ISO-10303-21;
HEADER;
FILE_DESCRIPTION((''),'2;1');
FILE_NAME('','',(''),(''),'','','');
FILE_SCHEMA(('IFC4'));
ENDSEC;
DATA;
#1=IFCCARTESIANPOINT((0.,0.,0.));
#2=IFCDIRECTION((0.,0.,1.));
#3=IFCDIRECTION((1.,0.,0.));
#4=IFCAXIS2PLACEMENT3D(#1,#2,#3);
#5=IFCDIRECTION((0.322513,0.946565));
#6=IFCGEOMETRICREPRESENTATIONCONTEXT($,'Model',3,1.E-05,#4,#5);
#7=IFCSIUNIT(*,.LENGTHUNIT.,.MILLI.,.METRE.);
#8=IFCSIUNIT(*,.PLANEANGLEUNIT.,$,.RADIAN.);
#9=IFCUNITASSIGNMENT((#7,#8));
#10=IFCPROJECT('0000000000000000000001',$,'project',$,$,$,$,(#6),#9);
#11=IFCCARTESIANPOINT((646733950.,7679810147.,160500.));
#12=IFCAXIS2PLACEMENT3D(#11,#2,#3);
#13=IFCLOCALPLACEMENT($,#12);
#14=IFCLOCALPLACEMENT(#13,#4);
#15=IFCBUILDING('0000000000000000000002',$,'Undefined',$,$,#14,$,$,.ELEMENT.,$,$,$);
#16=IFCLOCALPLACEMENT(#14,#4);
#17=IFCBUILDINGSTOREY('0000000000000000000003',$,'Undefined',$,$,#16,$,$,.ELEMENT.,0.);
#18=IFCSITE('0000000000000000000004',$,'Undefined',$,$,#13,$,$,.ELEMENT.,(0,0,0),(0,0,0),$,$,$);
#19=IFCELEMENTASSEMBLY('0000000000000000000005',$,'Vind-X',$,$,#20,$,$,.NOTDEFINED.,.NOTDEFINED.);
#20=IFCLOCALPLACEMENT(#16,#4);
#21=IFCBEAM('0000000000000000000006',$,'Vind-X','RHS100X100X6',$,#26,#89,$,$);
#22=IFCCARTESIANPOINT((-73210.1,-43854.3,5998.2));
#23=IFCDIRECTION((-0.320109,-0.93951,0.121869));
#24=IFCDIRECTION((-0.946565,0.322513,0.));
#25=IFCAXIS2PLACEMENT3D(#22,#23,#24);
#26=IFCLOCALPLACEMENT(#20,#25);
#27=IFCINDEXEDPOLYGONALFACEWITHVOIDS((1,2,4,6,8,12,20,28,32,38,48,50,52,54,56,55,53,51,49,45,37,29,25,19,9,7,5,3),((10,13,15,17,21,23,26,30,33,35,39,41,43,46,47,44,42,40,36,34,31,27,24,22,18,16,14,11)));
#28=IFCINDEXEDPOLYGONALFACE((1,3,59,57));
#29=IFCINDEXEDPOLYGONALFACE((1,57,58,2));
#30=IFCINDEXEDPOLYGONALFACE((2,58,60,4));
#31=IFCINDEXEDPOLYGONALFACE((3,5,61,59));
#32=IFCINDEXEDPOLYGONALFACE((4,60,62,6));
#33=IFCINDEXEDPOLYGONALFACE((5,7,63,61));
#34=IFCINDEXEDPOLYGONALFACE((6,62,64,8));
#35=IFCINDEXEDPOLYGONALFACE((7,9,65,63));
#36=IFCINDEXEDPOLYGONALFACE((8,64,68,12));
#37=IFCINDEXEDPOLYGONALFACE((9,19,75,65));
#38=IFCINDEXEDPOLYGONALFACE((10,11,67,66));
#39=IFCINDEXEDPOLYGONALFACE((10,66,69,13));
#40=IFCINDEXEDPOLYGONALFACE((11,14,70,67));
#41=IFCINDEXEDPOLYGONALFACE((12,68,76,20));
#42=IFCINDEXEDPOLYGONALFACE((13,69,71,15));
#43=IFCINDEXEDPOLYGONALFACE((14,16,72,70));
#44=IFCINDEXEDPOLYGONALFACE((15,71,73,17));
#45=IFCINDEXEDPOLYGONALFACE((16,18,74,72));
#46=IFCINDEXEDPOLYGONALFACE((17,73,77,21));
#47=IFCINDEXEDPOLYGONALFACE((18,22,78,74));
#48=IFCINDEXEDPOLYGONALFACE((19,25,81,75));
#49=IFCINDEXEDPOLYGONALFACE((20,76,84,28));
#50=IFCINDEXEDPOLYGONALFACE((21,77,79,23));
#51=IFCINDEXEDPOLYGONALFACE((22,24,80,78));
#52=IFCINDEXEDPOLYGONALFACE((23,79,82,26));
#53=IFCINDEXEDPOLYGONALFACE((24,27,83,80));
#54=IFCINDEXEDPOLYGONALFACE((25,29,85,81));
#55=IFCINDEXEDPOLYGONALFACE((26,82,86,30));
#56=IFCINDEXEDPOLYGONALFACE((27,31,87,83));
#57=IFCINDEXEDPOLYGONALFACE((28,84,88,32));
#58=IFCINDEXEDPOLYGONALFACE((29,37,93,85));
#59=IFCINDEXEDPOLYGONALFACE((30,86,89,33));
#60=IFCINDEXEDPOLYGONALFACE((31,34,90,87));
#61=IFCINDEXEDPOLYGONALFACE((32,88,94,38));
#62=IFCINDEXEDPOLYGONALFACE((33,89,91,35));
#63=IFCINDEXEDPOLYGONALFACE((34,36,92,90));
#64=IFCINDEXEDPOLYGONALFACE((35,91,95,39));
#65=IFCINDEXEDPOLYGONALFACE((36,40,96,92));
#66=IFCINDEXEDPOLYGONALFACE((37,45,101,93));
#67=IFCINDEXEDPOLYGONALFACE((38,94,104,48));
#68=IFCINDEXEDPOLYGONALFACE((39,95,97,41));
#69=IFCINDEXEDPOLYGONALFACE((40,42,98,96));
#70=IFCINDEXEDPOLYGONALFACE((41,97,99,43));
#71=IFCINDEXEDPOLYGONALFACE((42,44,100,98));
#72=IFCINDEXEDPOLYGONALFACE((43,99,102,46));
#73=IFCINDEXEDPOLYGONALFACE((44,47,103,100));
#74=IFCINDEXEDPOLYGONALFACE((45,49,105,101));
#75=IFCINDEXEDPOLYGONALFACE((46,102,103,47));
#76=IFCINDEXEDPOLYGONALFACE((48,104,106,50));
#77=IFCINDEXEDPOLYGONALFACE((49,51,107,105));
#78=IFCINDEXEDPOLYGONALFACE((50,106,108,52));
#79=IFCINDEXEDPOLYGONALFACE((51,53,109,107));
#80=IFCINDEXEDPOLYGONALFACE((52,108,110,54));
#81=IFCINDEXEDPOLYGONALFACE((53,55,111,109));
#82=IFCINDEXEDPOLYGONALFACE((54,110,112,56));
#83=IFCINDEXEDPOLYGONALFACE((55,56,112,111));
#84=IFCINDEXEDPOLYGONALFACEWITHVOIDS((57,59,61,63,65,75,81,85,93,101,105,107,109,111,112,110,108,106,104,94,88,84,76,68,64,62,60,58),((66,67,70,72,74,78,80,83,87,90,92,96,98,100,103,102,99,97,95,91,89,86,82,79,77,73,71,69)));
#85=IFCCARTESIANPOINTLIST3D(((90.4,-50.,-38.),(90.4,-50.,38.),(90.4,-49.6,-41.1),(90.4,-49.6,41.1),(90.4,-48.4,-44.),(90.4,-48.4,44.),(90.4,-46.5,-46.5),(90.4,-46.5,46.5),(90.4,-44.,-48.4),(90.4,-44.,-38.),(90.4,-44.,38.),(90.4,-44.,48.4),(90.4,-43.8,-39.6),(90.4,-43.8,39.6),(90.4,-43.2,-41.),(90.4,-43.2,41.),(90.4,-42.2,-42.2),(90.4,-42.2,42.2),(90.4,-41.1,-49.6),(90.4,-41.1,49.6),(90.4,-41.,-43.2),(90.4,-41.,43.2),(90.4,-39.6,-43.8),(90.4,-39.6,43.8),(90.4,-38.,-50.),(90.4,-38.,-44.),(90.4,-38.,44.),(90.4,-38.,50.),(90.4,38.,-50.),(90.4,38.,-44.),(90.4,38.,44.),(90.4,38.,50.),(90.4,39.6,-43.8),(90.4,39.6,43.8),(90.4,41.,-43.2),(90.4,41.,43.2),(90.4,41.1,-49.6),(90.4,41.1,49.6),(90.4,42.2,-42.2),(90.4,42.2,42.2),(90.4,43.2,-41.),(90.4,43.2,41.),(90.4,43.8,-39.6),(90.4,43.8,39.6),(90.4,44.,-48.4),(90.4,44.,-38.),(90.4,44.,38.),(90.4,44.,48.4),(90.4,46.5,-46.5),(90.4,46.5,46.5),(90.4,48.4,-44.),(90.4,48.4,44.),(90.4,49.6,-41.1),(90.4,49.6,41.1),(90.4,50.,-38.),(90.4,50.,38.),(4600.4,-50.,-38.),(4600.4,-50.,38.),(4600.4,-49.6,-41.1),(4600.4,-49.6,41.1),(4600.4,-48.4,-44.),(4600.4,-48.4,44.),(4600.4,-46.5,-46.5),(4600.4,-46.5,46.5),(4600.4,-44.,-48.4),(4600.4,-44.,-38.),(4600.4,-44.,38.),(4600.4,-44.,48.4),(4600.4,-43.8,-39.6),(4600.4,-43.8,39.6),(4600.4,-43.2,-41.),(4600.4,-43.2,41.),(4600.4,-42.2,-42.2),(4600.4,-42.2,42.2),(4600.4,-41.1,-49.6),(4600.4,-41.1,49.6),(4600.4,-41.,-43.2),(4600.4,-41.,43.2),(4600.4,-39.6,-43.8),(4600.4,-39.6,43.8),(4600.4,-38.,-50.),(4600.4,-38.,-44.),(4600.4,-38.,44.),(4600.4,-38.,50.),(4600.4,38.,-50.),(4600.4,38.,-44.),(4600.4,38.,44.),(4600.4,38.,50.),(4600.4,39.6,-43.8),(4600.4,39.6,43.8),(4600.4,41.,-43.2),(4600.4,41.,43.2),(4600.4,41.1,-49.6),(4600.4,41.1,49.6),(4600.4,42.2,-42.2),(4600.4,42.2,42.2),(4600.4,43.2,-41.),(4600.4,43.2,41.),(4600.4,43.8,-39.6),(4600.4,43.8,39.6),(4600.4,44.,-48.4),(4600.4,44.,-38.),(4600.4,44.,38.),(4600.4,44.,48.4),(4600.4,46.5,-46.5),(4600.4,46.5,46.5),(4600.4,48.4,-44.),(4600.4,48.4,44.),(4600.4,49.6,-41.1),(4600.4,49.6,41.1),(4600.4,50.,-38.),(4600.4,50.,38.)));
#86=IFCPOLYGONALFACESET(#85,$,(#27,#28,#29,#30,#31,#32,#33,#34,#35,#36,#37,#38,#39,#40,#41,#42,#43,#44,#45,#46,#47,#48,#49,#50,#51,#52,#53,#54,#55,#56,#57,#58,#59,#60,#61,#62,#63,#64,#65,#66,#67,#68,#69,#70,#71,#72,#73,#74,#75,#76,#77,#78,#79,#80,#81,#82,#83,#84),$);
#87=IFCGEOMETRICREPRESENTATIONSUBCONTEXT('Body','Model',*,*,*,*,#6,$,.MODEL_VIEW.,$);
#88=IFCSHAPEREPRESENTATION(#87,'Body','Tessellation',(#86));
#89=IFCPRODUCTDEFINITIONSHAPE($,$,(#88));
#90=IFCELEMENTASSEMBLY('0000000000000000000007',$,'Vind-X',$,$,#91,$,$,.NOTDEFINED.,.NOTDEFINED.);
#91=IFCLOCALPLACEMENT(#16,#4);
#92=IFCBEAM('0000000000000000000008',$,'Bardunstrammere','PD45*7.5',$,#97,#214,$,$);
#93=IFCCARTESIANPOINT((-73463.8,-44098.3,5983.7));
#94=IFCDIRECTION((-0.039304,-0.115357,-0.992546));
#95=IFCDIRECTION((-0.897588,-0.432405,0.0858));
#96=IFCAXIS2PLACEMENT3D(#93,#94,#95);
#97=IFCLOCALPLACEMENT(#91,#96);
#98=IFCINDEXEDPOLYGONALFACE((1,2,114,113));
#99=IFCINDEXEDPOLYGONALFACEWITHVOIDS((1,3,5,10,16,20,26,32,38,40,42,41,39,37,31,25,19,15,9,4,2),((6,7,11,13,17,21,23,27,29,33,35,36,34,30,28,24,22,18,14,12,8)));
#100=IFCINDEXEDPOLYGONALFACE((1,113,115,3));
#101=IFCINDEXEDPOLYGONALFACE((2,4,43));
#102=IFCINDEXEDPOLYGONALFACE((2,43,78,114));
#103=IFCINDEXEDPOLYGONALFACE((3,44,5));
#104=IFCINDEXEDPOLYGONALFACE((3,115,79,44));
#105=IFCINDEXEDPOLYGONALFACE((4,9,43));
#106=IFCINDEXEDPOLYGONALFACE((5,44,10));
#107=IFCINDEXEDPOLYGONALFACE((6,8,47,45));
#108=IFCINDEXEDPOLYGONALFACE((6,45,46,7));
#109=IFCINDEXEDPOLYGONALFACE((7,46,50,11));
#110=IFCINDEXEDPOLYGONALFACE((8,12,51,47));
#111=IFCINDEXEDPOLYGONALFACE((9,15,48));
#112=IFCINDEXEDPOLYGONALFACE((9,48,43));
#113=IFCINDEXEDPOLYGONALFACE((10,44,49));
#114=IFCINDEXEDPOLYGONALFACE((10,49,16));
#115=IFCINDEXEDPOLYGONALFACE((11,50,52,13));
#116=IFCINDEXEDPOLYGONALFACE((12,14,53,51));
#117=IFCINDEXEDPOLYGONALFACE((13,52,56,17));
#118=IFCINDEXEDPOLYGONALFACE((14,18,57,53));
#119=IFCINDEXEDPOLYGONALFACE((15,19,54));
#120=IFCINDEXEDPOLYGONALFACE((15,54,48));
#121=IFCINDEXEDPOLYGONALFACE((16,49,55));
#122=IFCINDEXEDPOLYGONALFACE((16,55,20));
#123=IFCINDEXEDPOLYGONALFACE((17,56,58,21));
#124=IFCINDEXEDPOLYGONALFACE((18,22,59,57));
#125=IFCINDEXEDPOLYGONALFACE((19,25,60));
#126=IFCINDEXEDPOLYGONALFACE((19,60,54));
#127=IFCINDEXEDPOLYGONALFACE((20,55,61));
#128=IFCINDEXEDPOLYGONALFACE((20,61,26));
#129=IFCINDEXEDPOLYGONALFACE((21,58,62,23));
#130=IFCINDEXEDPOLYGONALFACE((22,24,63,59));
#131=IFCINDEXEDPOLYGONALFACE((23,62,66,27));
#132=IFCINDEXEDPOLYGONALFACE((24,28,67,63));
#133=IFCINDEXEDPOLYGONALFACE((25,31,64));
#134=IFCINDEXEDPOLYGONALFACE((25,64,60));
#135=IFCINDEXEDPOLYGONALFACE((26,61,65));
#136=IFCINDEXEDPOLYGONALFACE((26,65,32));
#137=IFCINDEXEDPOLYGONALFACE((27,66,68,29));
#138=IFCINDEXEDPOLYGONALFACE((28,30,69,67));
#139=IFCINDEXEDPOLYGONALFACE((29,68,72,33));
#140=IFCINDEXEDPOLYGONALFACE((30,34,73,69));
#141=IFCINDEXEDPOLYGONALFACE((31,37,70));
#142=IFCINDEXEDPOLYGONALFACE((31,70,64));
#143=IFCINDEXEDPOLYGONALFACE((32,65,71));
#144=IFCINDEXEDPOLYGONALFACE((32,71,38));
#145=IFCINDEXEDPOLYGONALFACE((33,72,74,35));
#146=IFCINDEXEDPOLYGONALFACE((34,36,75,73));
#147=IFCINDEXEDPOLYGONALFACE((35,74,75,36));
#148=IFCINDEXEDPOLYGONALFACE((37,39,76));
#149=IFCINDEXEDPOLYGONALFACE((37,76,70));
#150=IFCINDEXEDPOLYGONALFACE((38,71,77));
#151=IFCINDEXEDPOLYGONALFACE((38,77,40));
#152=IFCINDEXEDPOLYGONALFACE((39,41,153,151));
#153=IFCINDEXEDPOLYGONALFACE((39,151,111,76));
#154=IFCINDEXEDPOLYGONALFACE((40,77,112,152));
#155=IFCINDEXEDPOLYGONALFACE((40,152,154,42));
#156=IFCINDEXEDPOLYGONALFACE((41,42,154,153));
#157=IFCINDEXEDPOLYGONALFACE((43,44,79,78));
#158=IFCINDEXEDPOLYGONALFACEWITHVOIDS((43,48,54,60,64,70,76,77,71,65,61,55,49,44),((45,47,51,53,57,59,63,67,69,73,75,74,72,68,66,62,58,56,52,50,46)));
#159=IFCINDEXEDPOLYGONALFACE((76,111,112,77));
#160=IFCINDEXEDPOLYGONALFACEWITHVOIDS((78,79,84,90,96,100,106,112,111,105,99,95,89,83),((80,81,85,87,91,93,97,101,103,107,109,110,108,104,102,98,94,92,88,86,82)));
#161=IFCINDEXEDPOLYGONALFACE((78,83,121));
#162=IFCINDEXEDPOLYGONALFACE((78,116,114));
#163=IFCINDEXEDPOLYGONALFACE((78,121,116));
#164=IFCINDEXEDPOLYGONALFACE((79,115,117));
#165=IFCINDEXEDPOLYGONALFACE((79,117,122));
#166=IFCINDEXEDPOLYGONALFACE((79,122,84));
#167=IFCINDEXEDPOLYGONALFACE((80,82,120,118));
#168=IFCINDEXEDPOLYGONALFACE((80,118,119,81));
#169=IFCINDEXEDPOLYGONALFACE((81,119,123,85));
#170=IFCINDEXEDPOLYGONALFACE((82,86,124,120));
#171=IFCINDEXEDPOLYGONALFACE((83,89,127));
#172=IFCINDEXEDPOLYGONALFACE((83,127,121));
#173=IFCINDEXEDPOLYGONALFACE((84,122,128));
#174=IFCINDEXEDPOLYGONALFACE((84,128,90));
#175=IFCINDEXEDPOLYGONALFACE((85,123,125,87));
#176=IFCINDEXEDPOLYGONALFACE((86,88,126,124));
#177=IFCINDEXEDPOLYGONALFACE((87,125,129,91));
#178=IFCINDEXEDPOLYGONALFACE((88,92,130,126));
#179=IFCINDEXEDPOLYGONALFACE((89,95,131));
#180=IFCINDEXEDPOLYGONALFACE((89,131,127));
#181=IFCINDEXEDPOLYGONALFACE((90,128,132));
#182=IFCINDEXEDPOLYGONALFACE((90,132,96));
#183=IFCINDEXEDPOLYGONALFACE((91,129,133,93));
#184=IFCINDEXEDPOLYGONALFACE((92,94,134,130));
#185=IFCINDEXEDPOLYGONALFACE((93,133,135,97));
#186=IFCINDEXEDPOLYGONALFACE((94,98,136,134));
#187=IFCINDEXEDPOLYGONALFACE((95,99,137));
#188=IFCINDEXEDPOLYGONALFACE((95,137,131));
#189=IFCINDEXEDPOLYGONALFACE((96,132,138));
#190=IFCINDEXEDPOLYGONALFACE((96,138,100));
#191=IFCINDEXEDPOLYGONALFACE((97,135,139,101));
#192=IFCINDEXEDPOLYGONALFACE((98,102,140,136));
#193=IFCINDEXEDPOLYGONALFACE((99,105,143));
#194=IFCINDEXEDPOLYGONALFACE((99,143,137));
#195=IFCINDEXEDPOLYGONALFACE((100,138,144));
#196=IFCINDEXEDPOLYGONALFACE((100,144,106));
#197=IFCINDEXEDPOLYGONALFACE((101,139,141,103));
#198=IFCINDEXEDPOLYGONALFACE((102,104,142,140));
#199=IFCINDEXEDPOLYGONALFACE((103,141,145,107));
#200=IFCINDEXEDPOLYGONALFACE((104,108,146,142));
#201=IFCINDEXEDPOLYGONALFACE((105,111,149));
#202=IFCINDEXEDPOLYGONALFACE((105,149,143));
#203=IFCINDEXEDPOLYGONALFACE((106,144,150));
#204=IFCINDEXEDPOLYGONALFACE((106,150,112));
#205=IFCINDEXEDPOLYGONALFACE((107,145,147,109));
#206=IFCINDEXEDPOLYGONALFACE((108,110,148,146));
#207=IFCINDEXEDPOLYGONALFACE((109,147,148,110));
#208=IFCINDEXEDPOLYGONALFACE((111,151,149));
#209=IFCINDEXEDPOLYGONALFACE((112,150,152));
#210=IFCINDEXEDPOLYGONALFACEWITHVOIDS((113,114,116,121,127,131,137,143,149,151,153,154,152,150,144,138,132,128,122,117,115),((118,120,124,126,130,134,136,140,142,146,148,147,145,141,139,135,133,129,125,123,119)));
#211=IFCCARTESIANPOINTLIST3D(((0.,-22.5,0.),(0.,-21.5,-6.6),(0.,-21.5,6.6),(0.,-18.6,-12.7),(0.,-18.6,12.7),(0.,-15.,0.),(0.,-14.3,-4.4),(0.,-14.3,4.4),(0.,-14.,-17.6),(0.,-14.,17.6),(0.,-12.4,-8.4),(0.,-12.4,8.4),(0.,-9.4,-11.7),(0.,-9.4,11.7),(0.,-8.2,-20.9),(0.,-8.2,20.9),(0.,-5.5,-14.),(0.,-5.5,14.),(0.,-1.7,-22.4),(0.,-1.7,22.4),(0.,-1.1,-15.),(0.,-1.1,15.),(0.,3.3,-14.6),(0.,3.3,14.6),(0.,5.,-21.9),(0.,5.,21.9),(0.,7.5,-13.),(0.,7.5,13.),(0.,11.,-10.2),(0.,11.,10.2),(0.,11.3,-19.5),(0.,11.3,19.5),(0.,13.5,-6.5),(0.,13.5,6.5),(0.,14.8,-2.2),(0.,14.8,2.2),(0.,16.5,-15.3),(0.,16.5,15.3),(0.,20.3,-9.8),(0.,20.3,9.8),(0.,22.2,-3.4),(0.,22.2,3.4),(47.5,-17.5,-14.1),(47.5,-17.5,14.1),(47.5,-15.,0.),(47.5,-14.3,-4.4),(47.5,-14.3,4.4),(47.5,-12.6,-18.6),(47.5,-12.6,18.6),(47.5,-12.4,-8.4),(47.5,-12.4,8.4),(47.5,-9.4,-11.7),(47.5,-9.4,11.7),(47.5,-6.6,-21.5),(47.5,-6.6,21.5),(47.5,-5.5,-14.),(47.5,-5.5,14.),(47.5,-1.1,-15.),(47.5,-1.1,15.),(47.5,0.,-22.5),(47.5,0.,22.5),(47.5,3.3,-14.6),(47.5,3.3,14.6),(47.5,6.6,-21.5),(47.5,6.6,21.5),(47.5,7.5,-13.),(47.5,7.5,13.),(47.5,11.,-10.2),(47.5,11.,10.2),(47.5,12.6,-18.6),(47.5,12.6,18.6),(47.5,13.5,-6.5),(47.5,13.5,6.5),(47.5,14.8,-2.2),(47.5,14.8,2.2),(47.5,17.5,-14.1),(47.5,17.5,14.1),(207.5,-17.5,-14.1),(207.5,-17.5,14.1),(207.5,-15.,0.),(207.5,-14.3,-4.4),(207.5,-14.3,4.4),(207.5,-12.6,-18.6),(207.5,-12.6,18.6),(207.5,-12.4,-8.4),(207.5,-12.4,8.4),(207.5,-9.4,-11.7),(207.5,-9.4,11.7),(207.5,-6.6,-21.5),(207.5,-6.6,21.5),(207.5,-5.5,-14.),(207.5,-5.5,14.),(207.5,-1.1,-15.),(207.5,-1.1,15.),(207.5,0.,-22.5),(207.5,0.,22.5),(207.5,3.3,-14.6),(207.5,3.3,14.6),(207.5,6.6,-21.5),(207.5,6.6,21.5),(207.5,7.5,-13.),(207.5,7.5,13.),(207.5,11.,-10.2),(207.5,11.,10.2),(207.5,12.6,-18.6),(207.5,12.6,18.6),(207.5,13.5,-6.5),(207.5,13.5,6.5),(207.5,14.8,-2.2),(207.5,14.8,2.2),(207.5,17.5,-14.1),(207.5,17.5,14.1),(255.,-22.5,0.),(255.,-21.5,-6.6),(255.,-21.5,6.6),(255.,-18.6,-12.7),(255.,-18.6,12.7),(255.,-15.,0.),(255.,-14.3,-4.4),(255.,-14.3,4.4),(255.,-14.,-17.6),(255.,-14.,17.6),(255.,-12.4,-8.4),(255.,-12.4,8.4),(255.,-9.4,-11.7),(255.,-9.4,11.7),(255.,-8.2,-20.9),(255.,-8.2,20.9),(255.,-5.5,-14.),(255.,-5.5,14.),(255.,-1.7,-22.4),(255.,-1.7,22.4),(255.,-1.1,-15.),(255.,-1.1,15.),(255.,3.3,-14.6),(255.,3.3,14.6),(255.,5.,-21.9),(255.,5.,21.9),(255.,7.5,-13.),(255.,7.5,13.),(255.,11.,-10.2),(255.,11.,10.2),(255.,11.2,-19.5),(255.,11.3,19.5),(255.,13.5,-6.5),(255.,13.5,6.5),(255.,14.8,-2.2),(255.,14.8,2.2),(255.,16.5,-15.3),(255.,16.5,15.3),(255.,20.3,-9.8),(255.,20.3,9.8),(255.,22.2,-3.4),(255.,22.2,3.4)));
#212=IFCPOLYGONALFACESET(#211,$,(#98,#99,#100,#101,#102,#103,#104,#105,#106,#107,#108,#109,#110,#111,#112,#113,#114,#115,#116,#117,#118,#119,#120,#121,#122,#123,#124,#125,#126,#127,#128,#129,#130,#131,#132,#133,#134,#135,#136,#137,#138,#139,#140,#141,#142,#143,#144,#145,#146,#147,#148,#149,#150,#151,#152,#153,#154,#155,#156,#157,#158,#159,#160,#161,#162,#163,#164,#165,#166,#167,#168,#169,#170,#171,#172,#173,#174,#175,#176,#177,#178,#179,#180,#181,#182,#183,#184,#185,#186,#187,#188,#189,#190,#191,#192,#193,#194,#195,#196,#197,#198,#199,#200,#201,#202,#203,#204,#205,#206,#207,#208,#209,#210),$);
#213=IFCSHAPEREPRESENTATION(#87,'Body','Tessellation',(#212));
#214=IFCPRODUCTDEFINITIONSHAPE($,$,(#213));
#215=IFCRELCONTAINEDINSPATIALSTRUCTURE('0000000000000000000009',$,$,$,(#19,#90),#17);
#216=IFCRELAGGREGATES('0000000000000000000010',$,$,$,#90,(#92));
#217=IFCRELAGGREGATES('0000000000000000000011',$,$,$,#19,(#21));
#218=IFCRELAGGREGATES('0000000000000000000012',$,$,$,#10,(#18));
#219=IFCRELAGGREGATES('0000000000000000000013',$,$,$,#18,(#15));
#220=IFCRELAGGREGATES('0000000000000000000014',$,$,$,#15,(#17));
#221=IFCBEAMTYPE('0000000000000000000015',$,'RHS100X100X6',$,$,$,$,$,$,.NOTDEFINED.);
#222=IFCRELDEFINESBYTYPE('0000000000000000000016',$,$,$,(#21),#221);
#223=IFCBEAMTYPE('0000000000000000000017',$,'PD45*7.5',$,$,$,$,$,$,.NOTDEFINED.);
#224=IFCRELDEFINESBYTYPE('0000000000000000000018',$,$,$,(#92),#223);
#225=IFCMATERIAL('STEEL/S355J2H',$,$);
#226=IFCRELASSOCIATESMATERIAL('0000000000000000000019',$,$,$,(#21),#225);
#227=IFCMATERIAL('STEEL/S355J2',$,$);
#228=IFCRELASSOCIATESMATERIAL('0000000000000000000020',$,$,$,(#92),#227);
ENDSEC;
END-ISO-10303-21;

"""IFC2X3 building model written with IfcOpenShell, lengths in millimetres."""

from ifc_helpers import new_model, si_unit, direction, frame, origin_with_axes, origin_2d_with_axis, place, context, subcontext, project, spatial, rectangle, hollow_rectangle, hollow_circle, extrude, boolean, clip, halfspace, material, type_object, element, aggregate, save


model = new_model("IFC2X3")

# Units and contexts
model_context = context("Model", 3, precision=1e-05, world=origin_with_axes(), true_north=direction((0.322513, 0.946565)))
body_context = subcontext(model_context, "Body", "Model", "MODEL_VIEW")
ifc_project = project(units=[si_unit("LENGTHUNIT", "METRE", prefix="MILLI"), si_unit("PLANEANGLEUNIT", "RADIAN")], contexts=[model_context])

# Site, building, storey
site_placement = place(None, frame((646733950.0, 7679810147.0, 160500.0), z_axis=(0.0, 0.0, 1.0), x_axis=(1.0, 0.0, 0.0)))
site = spatial("IfcSite", under=ifc_project, at=site_placement, Name="Undefined", CompositionType="ELEMENT", RefLatitude=(0, 0, 0), RefLongitude=(0, 0, 0))
building_placement = place(site_placement, origin_with_axes())
building = spatial("IfcBuilding", under=site, at=building_placement, Name="Undefined", CompositionType="ELEMENT")
storey_placement = place(building_placement, origin_with_axes())
storey = spatial("IfcBuildingStorey", under=building, at=storey_placement, Name="Undefined", CompositionType="ELEMENT", Elevation=0.0)

# Element assembly, beam
ifc_material_1 = material(Name="STEEL/S355J2H")
beam_type_1 = type_object("IfcBeamType", Name="RHS100X100X6", PredefinedType="NOTDEFINED")
assembly_1_placement = place(storey_placement, origin_with_axes())
assembly_1 = element("IfcElementAssembly", 1, at=assembly_1_placement, inside=storey, Name="Vind-X", AssemblyPlace="NOTDEFINED", PredefinedType="NOTDEFINED")
beam_1_placement = place(assembly_1_placement, frame((-73210.1, -43854.3, 5998.2), z_axis=(-0.320109, -0.93951, 0.121869), x_axis=(-0.946565, 0.322513, 0.0)))
beam_1 = element("IfcBeam", 2, at=beam_1_placement, type_object=beam_type_1, material=ifc_material_1, Name="Vind-X", Description="RHS100X100X6", context=body_context, shape_type="Clipping", body=[
    clip(clip(extrude(hollow_rectangle(XDim=100.0, YDim=100.0, WallThickness=6.0, InnerFilletRadius=6.0, OuterFilletRadius=12.0, at=origin_2d_with_axis()), frame((4690.0, 0.0, 0.0), z_axis=(-1.0, 0.0, 0.0), x_axis=(0.0, -1.0, 0.0)), (0.0, 0.0, 1.0), 4690.0), halfspace(frame((4600.4, 7.5, 0.0), z_axis=(-1.0, 0.0, 0.0), x_axis=(0.0, 0.0, -1.0)), True)), halfspace(frame((90.4, 7.5, 0.0), z_axis=(1.0, 0.0, 0.0), x_axis=(0.0, 0.0, 1.0)), True)),
])

# Element assembly, beam
assembly_2_placement = place(storey_placement, origin_with_axes())
assembly_2 = element("IfcElementAssembly", 3, at=assembly_2_placement, inside=storey, Name="Vind-X", AssemblyPlace="NOTDEFINED", PredefinedType="NOTDEFINED")
ifc_material_2 = material(Name="STEEL/S355J2")
beam_type_2 = type_object("IfcBeamType", Name="PD45*7.5", PredefinedType="NOTDEFINED")
beam_2_placement = place(assembly_2_placement, frame((-73463.8, -44098.3, 5983.7), z_axis=(-0.039304, -0.115357, -0.992546), x_axis=(-0.897588, -0.432405, 0.0858)))
beam_2 = element("IfcBeam", 4, at=beam_2_placement, type_object=beam_type_2, material=ifc_material_2, Name="Bardunstrammere", Description="PD45*7.5", context=body_context, shape_type="CSG", body=[
    boolean("DIFFERENCE", extrude(hollow_circle(Radius=22.5, WallThickness=7.5, at=origin_2d_with_axis()), frame((255.0, 0.0, 0.0), z_axis=(-1.0, 0.0, 0.0), x_axis=(0.0, -1.0, 0.0)), (0.0, 0.0, 1.0), 255.0), extrude(rectangle(XDim=35.0, YDim=90.0, at=origin_2d_with_axis()), frame((207.5, 0.0, 0.0), z_axis=(-1.0, 0.0, 0.0), x_axis=(0.0, -1.0, 0.0)), (0.0, 0.0, 1.0), 160.0)),
])

aggregate(assembly_2, [beam_2])

aggregate(assembly_1, [beam_1])

save(model, "model.ifc")
